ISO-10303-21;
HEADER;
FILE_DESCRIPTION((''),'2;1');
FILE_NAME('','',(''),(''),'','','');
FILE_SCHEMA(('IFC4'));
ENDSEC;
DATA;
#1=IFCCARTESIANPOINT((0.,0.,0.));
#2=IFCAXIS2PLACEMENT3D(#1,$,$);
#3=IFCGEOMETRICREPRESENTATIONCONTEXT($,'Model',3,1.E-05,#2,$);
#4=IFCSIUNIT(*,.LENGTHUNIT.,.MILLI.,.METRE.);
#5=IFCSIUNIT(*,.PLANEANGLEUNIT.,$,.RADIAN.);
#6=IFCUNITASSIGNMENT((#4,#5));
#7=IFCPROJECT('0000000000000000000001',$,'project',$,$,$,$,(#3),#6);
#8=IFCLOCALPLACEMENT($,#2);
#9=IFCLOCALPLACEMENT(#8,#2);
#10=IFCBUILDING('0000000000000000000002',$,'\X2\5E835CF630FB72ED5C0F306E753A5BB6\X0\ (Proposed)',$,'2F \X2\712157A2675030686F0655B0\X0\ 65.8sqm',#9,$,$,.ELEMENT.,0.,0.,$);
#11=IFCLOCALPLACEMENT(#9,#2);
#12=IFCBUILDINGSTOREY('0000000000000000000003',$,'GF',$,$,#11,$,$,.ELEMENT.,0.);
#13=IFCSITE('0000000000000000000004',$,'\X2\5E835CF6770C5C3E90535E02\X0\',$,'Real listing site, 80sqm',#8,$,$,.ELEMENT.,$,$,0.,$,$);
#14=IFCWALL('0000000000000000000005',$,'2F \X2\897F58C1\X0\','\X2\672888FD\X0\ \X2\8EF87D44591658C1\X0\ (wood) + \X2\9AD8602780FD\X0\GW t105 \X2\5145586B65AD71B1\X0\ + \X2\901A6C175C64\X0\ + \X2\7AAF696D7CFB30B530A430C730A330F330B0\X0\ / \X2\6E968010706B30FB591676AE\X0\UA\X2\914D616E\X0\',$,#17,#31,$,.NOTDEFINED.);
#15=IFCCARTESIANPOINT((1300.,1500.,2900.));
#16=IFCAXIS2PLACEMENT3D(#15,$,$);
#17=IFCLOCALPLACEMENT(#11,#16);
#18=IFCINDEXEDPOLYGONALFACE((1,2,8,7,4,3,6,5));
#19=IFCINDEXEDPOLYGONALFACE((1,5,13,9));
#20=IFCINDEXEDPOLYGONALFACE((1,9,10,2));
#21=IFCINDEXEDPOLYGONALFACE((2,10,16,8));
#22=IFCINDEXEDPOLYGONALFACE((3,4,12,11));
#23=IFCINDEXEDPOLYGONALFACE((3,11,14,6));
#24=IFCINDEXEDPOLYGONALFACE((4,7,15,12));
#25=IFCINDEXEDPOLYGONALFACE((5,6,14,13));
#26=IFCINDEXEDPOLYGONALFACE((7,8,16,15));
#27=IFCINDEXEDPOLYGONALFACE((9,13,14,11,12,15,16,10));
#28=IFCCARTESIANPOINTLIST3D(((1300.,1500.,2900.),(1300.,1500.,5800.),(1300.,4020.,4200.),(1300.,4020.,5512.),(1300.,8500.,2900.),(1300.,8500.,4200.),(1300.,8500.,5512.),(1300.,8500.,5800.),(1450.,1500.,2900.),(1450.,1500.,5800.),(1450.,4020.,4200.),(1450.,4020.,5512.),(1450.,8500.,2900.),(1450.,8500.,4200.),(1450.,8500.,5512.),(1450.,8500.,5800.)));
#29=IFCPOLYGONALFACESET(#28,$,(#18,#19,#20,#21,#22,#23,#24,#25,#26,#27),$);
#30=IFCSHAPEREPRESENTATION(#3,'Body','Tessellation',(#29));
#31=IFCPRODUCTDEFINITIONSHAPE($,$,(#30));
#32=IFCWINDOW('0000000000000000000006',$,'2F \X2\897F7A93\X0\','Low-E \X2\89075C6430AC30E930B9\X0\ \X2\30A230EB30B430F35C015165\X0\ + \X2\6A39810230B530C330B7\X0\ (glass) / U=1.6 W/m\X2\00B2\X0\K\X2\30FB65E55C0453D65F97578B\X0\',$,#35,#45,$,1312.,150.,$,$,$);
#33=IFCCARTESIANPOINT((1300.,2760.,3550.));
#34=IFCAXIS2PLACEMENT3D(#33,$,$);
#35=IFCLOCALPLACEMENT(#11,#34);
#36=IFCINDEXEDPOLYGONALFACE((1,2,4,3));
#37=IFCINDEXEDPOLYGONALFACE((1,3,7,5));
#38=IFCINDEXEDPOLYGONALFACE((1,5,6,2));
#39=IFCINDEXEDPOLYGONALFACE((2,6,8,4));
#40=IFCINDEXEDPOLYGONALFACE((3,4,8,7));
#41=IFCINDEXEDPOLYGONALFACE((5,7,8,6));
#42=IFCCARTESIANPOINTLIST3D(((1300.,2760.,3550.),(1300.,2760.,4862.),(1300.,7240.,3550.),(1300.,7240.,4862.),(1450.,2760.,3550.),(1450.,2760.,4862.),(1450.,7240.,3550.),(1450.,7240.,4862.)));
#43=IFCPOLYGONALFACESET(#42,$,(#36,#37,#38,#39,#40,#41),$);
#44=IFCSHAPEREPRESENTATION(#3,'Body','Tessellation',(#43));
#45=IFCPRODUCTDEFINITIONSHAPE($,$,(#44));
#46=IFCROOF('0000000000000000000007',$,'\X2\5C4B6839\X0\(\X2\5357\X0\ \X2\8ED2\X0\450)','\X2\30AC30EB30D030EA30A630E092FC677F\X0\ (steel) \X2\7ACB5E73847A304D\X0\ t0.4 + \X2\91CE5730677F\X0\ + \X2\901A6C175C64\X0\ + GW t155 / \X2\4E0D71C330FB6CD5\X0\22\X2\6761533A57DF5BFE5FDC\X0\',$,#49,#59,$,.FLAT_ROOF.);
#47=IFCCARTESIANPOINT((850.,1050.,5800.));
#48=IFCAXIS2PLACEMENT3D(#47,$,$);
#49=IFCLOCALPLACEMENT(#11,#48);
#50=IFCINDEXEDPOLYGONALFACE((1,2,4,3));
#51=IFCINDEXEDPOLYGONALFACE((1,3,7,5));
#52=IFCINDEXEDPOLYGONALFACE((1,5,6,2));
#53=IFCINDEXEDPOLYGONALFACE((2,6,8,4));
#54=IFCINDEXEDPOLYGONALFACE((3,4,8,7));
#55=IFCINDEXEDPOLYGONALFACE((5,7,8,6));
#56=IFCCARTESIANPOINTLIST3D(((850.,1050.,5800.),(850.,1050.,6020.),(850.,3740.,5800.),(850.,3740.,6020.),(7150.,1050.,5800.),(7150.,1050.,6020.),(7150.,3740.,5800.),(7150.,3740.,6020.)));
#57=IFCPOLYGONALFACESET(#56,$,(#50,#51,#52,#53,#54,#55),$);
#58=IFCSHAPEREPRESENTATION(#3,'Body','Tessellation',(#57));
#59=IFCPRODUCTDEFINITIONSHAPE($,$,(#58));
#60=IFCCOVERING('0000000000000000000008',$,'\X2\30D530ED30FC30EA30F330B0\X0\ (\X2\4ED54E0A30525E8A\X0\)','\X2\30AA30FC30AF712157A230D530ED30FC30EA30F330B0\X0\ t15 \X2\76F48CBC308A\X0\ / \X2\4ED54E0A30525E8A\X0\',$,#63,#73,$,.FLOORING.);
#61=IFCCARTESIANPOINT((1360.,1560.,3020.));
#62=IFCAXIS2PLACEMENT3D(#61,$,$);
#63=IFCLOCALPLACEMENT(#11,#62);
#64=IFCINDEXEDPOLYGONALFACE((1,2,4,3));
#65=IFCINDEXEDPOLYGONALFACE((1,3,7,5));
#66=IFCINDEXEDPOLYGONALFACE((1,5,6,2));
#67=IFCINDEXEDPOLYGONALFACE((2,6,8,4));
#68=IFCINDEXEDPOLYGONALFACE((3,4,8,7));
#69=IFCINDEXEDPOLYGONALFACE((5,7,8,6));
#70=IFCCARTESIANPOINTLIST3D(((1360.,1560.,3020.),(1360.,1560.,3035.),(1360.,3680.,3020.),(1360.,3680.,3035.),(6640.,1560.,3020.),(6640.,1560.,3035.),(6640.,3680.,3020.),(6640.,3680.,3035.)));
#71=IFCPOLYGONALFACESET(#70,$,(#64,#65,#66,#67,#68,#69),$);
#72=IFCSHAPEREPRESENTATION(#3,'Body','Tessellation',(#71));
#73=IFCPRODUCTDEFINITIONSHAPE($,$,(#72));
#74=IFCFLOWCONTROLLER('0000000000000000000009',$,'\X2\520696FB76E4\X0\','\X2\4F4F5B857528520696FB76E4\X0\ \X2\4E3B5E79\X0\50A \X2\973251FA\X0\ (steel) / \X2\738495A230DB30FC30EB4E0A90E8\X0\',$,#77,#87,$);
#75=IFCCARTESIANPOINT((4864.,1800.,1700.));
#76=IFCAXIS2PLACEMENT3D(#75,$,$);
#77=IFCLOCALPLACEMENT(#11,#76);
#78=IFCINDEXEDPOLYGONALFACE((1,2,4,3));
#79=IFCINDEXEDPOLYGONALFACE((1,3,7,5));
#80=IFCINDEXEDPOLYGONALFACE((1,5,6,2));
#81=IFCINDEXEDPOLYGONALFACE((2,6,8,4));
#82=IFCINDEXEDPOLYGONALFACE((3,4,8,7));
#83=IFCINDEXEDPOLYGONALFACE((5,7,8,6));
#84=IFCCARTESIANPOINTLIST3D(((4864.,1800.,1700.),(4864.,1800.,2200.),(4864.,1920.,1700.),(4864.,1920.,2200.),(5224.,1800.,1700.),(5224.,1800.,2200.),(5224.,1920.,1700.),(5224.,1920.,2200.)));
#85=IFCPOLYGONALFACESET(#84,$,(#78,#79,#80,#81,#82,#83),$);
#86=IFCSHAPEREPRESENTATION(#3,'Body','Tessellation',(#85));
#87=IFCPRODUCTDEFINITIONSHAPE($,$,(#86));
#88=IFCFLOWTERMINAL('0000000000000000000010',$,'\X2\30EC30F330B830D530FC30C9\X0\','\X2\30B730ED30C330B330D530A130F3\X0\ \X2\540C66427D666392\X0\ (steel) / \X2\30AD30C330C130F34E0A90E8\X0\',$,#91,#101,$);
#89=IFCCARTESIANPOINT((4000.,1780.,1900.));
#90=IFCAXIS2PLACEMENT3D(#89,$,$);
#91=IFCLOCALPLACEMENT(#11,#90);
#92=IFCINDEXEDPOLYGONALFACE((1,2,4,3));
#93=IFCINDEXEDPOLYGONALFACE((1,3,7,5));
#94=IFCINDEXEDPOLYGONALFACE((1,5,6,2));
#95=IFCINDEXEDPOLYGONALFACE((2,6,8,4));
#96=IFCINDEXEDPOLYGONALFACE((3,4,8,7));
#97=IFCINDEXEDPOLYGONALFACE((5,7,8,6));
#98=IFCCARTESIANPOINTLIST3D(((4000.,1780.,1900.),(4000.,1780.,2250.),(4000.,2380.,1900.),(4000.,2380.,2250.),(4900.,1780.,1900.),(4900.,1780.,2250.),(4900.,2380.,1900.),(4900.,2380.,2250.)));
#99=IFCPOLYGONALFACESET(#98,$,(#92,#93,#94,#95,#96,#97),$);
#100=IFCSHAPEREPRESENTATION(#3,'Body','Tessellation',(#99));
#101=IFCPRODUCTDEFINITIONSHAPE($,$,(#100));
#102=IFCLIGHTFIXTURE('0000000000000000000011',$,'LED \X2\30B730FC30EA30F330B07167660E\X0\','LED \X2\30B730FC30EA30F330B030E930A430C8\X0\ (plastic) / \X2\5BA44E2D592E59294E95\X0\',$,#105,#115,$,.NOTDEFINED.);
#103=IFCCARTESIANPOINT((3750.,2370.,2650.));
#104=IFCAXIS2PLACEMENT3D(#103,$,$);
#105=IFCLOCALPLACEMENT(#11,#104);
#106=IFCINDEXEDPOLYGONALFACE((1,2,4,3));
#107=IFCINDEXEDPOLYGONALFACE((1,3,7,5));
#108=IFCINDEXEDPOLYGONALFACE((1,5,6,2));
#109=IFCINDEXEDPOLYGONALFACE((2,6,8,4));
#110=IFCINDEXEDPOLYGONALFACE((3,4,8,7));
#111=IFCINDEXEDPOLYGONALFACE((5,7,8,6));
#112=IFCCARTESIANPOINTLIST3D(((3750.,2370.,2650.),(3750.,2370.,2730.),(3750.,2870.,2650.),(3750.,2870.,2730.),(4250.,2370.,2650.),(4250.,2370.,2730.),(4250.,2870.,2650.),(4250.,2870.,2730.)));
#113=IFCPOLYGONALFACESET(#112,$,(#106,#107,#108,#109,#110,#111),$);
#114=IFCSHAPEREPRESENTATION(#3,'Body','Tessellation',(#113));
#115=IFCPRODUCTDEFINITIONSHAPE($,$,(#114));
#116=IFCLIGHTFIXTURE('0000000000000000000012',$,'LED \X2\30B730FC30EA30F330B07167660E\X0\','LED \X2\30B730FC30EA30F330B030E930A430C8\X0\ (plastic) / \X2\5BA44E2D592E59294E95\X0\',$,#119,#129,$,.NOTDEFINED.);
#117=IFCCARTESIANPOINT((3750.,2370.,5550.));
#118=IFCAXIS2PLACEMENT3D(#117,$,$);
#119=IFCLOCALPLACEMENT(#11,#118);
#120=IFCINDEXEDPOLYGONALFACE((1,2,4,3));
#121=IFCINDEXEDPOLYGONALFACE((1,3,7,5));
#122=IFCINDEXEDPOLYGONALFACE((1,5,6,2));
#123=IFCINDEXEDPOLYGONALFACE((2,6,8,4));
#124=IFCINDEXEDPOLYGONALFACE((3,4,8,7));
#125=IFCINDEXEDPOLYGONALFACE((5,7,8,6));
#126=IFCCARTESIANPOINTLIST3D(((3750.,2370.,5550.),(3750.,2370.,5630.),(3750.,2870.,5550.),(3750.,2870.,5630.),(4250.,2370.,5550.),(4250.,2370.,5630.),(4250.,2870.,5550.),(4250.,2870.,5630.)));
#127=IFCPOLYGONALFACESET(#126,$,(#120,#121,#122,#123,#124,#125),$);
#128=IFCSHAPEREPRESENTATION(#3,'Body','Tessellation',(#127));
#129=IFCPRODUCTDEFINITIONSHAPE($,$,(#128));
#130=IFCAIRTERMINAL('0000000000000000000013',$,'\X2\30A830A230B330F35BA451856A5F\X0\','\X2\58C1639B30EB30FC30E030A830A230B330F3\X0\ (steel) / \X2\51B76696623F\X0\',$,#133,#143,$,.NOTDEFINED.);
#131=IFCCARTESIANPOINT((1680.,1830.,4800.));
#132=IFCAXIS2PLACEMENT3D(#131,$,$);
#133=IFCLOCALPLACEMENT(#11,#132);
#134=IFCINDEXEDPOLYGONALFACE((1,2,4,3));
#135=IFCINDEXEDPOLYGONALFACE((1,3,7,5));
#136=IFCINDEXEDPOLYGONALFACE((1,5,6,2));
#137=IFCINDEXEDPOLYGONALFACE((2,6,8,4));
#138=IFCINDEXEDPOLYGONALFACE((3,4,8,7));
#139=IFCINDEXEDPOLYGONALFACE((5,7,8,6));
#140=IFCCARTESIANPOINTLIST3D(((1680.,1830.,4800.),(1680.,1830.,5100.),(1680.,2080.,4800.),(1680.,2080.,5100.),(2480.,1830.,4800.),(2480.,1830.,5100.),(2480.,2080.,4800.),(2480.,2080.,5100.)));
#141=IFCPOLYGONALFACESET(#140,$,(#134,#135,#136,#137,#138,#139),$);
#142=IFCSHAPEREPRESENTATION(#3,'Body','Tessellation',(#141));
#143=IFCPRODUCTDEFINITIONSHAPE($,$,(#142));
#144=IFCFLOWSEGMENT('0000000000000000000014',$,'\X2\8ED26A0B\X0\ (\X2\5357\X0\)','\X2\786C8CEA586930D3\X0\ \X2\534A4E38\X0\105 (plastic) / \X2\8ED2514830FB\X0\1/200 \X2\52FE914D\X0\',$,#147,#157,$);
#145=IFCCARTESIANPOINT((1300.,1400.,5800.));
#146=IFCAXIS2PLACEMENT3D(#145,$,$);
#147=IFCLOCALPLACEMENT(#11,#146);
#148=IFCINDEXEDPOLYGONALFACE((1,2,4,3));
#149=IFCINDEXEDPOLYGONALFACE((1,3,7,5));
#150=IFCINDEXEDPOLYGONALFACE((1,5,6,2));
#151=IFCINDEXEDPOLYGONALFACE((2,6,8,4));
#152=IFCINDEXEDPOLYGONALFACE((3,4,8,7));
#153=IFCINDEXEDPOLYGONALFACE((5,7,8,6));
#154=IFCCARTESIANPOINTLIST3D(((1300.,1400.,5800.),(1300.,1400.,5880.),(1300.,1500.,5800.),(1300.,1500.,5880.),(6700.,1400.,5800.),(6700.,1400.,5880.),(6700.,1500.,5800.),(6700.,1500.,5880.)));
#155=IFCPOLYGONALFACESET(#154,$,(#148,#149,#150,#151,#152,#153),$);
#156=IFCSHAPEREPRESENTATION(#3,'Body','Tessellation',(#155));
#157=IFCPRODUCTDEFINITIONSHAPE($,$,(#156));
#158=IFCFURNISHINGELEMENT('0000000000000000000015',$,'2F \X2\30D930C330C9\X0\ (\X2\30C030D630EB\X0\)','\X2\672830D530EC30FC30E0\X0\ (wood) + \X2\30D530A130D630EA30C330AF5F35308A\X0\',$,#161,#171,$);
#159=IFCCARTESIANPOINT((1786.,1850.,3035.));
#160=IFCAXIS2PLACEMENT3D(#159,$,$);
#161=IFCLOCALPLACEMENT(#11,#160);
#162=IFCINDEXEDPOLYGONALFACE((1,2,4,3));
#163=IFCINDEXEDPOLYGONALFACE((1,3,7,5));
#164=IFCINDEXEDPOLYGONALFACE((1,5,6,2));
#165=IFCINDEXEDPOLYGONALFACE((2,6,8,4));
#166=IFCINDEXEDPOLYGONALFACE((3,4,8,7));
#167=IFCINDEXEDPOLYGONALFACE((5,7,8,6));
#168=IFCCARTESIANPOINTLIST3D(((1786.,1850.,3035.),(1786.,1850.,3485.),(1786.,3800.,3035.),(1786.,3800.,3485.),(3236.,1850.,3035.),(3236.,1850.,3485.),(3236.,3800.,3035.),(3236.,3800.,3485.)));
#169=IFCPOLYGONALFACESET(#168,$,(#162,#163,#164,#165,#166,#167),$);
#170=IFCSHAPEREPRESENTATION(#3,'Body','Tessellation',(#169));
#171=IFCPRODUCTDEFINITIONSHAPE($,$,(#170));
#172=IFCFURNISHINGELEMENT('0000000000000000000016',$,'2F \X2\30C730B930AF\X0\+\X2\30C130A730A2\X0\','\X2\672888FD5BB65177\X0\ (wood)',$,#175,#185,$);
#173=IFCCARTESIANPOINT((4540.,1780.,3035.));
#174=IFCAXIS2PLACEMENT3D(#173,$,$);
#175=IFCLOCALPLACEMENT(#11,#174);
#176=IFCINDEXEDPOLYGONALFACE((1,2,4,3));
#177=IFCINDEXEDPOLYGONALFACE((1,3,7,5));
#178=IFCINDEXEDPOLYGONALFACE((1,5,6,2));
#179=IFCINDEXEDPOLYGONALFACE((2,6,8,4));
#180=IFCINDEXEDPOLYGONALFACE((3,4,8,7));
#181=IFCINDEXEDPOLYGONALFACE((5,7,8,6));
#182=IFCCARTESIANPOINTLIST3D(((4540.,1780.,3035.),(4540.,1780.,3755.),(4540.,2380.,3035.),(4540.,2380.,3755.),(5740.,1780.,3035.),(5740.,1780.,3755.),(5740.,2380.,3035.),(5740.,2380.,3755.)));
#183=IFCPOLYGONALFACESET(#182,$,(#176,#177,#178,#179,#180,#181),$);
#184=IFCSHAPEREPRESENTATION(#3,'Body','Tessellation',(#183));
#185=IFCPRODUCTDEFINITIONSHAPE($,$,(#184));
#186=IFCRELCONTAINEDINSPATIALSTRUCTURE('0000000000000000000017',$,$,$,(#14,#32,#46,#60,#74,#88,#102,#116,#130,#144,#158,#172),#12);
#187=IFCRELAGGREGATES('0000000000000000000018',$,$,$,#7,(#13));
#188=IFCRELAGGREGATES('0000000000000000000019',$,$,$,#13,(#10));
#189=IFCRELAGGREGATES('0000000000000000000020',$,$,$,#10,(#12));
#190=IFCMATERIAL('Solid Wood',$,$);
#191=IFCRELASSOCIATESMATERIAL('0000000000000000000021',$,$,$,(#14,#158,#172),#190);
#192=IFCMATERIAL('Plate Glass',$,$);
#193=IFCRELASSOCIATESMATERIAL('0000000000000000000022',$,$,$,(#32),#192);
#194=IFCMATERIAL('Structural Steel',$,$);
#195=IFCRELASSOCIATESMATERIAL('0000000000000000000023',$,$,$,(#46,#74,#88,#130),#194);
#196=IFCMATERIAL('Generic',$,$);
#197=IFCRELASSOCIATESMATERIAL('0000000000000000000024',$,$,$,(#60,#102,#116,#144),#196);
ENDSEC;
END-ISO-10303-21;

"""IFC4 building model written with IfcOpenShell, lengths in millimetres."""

from ifc_helpers import new_model, si_unit, frame, frame_2d, origin, place, context, project, spatial, rectangle, extrude, material, element, fill, save


model = new_model("IFC4")

# Units and contexts
model_context = context("Model", 3, precision=1e-05, world=origin())
ifc_project = project(units=[si_unit("LENGTHUNIT", "METRE", prefix="MILLI"), si_unit("PLANEANGLEUNIT", "RADIAN")], contexts=[model_context])

# Site, building, storey
site_placement = place(None, origin())
site = spatial("IfcSite", under=ifc_project, at=site_placement, Name="広島県尾道市", ObjectType="Real listing site, 80sqm", CompositionType="ELEMENT", RefElevation=0.0)
building_placement = place(site_placement, origin())
building = spatial("IfcBuilding", under=site, at=building_placement, Name="広島・狭小の町家 (Proposed)", ObjectType="2F 無垢材と漆喰 65.8sqm", CompositionType="ELEMENT", ElevationOfRefHeight=0.0, ElevationOfTerrain=0.0)
storey_placement = place(building_placement, origin())
storey = spatial("IfcBuildingStorey", under=building, at=storey_placement, Name="GF", CompositionType="ELEMENT", Elevation=0.0)

# Shared definitions
ifc_material_1 = material(Name="Solid Wood")

# Wall, opening, window
ifc_material_2 = material(Name="Plate Glass")
wall_1_placement = place(storey_placement, frame((1300.0, 1500.0, 2900.0)))
wall_1 = element("IfcWall", 1, at=wall_1_placement, inside=storey, material=ifc_material_1, Name="2F 西壁", Description="木製 軸組外壁 (wood) + 高性能GW t105 充填断熱 + 通気層 + 窯業系サイディング / 準耐火・外皮UA配慮", PredefinedType="NOTDEFINED", context=model_context, shape_type="SweptSolid", body=[
    extrude(rectangle(XDim=150.0, YDim=7000.0, at=frame_2d((75.0, 3500.0))), frame((1300.0, 1500.0, 2900.0)), (0.0, 0.0, 1.0), 2900.0),
])
opening_1_placement = place(storey_placement, frame((1300.0, 2760.0, 3550.0)))
opening_1 = element("IfcOpeningElement", 2, at=opening_1_placement, cuts=wall_1, PredefinedType="NOTDEFINED", context=model_context, shape_type="SweptSolid", body=[
    extrude(rectangle(XDim=150.0, YDim=4480.0, at=frame_2d((75.0, 2240.0))), frame((1300.0, 2760.0, 3550.0)), (0.0, 0.0, 1.0), 1312.0),
])
window_1_placement = place(storey_placement, frame((1300.0, 2760.0, 3550.0)))
window_1 = element("IfcWindow", 3, at=window_1_placement, inside=storey, material=ifc_material_2, Name="2F 西窓", Description="Low-E 複層ガラス アルゴン封入 + 樹脂サッシ (glass) / U=1.6 W/m²K・日射取得型", OverallHeight=1312.0, OverallWidth=150.0, context=model_context, shape_type="SweptSolid", body=[
    extrude(rectangle(XDim=150.0, YDim=4480.0, at=frame_2d((75.0, 2240.0))), frame((1300.0, 2760.0, 3550.0)), (0.0, 0.0, 1.0), 1312.0),
])
fill(opening_1, window_1)

# Roof
ifc_material_3 = material(Name="Structural Steel")
for number, where, name in (
    (4, (850.0, 1050.0, 5800.0), "屋根(南 軒450)"),
):
    element("IfcRoof", number, at=place(storey_placement, frame(where)), inside=storey, material=ifc_material_3, Name=name, Description="ガルバリウム鋼板 (steel) 立平葺き t0.4 + 野地板 + 通気層 + GW t155 / 不燃・法22条区域対応", PredefinedType="FLAT_ROOF", context=model_context, shape_type="SweptSolid", body=[
        extrude(rectangle(XDim=6300.0, YDim=2690.0, at=frame_2d((3150.0, 1345.0))), frame((850.0, 1050.0, 5800.0)), (0.0, 0.0, 1.0), 220.0),
    ])

# Covering
ifc_material_4 = material(Name="Generic")
covering_placement = place(storey_placement, frame((1360.0, 1560.0, 3020.0)))
element("IfcCovering", 5, at=covering_placement, inside=storey, material=ifc_material_4, Name="フローリング (仕上げ床)", Description="オーク無垢フローリング t15 直貼り / 仕上げ床", PredefinedType="FLOORING", context=model_context, shape_type="SweptSolid", body=[
    extrude(rectangle(XDim=5280.0, YDim=2120.0, at=frame_2d((2640.0, 1060.0))), frame((1360.0, 1560.0, 3020.0)), (0.0, 0.0, 1.0), 15.0),
])

# Flow controller
flow_controller_placement = place(storey_placement, frame((4864.0, 1800.0, 1700.0)))
element("IfcFlowController", 6, at=flow_controller_placement, inside=storey, material=ifc_material_3, Name="分電盤", Description="住宅用分電盤 主幹50A 露出 (steel) / 玄関ホール上部", context=model_context, shape_type="SweptSolid", body=[
    extrude(rectangle(XDim=360.0, YDim=120.0, at=frame_2d((180.0, 60.0))), frame((4864.0, 1800.0, 1700.0)), (0.0, 0.0, 1.0), 500.0),
])

# Flow terminal
flow_terminal_placement = place(storey_placement, frame((4000.0, 1780.0, 1900.0)))
element("IfcFlowTerminal", 7, at=flow_terminal_placement, inside=storey, material=ifc_material_3, Name="レンジフード", Description="シロッコファン 同時給排 (steel) / キッチン上部", context=model_context, shape_type="SweptSolid", body=[
    extrude(rectangle(XDim=900.0, YDim=600.0, at=frame_2d((450.0, 300.0))), frame((4000.0, 1780.0, 1900.0)), (0.0, 0.0, 1.0), 350.0),
])

# Light fixtures
light_fixture_1_placement = place(storey_placement, frame((3750.0, 2370.0, 2650.0)))
element("IfcLightFixture", 8, at=light_fixture_1_placement, inside=storey, material=ifc_material_4, Name="LED シーリング照明", Description="LED シーリングライト (plastic) / 室中央天井", PredefinedType="NOTDEFINED", context=model_context, shape_type="SweptSolid", body=[
    extrude(rectangle(XDim=500.0, YDim=500.0, at=frame_2d((250.0, 250.0))), frame((3750.0, 2370.0, 2650.0)), (0.0, 0.0, 1.0), 80.0),
])
light_fixture_2_placement = place(storey_placement, frame((3750.0, 2370.0, 5550.0)))
element("IfcLightFixture", 9, at=light_fixture_2_placement, inside=storey, material=ifc_material_4, Name="LED シーリング照明", Description="LED シーリングライト (plastic) / 室中央天井", PredefinedType="NOTDEFINED", context=model_context, shape_type="SweptSolid", body=[
    extrude(rectangle(XDim=500.0, YDim=500.0, at=frame_2d((250.0, 250.0))), frame((3750.0, 2370.0, 5550.0)), (0.0, 0.0, 1.0), 80.0),
])

# Air terminal
air_terminal_placement = place(storey_placement, frame((1680.0, 1830.0, 4800.0)))
element("IfcAirTerminal", 10, at=air_terminal_placement, inside=storey, material=ifc_material_3, Name="エアコン室内機", Description="壁掛ルームエアコン (steel) / 冷暖房", PredefinedType="NOTDEFINED", context=model_context, shape_type="SweptSolid", body=[
    extrude(rectangle(XDim=800.0, YDim=250.0, at=frame_2d((400.0, 125.0))), frame((1680.0, 1830.0, 4800.0)), (0.0, 0.0, 1.0), 300.0),
])

# Flow segment
flow_segment_placement = place(storey_placement, frame((1300.0, 1400.0, 5800.0)))
element("IfcFlowSegment", 11, at=flow_segment_placement, inside=storey, material=ifc_material_4, Name="軒樋 (南)", Description="硬質塩ビ 半丸105 (plastic) / 軒先・1/200 勾配", context=model_context, shape_type="SweptSolid", body=[
    extrude(rectangle(XDim=5400.0, YDim=100.0, at=frame_2d((2700.0, 50.0))), frame((1300.0, 1400.0, 5800.0)), (0.0, 0.0, 1.0), 80.0),
])

# Furnishing elements
furnishing_1_placement = place(storey_placement, frame((1786.0, 1850.0, 3035.0)))
element("IfcFurnishingElement", 12, at=furnishing_1_placement, inside=storey, material=ifc_material_1, Name="2F ベッド (ダブル)", Description="木フレーム (wood) + ファブリック張り", context=model_context, shape_type="SweptSolid", body=[
    extrude(rectangle(XDim=1450.0, YDim=1950.0, at=frame_2d((725.0, 975.0))), frame((1786.0, 1850.0, 3035.0)), (0.0, 0.0, 1.0), 450.0),
])
furnishing_2_placement = place(storey_placement, frame((4540.0, 1780.0, 3035.0)))
element("IfcFurnishingElement", 13, at=furnishing_2_placement, inside=storey, material=ifc_material_1, Name="2F デスク+チェア", Description="木製家具 (wood)", context=model_context, shape_type="SweptSolid", body=[
    extrude(rectangle(XDim=1200.0, YDim=600.0, at=frame_2d((600.0, 300.0))), frame((4540.0, 1780.0, 3035.0)), (0.0, 0.0, 1.0), 720.0),
])

save(model, "model.ifc")
